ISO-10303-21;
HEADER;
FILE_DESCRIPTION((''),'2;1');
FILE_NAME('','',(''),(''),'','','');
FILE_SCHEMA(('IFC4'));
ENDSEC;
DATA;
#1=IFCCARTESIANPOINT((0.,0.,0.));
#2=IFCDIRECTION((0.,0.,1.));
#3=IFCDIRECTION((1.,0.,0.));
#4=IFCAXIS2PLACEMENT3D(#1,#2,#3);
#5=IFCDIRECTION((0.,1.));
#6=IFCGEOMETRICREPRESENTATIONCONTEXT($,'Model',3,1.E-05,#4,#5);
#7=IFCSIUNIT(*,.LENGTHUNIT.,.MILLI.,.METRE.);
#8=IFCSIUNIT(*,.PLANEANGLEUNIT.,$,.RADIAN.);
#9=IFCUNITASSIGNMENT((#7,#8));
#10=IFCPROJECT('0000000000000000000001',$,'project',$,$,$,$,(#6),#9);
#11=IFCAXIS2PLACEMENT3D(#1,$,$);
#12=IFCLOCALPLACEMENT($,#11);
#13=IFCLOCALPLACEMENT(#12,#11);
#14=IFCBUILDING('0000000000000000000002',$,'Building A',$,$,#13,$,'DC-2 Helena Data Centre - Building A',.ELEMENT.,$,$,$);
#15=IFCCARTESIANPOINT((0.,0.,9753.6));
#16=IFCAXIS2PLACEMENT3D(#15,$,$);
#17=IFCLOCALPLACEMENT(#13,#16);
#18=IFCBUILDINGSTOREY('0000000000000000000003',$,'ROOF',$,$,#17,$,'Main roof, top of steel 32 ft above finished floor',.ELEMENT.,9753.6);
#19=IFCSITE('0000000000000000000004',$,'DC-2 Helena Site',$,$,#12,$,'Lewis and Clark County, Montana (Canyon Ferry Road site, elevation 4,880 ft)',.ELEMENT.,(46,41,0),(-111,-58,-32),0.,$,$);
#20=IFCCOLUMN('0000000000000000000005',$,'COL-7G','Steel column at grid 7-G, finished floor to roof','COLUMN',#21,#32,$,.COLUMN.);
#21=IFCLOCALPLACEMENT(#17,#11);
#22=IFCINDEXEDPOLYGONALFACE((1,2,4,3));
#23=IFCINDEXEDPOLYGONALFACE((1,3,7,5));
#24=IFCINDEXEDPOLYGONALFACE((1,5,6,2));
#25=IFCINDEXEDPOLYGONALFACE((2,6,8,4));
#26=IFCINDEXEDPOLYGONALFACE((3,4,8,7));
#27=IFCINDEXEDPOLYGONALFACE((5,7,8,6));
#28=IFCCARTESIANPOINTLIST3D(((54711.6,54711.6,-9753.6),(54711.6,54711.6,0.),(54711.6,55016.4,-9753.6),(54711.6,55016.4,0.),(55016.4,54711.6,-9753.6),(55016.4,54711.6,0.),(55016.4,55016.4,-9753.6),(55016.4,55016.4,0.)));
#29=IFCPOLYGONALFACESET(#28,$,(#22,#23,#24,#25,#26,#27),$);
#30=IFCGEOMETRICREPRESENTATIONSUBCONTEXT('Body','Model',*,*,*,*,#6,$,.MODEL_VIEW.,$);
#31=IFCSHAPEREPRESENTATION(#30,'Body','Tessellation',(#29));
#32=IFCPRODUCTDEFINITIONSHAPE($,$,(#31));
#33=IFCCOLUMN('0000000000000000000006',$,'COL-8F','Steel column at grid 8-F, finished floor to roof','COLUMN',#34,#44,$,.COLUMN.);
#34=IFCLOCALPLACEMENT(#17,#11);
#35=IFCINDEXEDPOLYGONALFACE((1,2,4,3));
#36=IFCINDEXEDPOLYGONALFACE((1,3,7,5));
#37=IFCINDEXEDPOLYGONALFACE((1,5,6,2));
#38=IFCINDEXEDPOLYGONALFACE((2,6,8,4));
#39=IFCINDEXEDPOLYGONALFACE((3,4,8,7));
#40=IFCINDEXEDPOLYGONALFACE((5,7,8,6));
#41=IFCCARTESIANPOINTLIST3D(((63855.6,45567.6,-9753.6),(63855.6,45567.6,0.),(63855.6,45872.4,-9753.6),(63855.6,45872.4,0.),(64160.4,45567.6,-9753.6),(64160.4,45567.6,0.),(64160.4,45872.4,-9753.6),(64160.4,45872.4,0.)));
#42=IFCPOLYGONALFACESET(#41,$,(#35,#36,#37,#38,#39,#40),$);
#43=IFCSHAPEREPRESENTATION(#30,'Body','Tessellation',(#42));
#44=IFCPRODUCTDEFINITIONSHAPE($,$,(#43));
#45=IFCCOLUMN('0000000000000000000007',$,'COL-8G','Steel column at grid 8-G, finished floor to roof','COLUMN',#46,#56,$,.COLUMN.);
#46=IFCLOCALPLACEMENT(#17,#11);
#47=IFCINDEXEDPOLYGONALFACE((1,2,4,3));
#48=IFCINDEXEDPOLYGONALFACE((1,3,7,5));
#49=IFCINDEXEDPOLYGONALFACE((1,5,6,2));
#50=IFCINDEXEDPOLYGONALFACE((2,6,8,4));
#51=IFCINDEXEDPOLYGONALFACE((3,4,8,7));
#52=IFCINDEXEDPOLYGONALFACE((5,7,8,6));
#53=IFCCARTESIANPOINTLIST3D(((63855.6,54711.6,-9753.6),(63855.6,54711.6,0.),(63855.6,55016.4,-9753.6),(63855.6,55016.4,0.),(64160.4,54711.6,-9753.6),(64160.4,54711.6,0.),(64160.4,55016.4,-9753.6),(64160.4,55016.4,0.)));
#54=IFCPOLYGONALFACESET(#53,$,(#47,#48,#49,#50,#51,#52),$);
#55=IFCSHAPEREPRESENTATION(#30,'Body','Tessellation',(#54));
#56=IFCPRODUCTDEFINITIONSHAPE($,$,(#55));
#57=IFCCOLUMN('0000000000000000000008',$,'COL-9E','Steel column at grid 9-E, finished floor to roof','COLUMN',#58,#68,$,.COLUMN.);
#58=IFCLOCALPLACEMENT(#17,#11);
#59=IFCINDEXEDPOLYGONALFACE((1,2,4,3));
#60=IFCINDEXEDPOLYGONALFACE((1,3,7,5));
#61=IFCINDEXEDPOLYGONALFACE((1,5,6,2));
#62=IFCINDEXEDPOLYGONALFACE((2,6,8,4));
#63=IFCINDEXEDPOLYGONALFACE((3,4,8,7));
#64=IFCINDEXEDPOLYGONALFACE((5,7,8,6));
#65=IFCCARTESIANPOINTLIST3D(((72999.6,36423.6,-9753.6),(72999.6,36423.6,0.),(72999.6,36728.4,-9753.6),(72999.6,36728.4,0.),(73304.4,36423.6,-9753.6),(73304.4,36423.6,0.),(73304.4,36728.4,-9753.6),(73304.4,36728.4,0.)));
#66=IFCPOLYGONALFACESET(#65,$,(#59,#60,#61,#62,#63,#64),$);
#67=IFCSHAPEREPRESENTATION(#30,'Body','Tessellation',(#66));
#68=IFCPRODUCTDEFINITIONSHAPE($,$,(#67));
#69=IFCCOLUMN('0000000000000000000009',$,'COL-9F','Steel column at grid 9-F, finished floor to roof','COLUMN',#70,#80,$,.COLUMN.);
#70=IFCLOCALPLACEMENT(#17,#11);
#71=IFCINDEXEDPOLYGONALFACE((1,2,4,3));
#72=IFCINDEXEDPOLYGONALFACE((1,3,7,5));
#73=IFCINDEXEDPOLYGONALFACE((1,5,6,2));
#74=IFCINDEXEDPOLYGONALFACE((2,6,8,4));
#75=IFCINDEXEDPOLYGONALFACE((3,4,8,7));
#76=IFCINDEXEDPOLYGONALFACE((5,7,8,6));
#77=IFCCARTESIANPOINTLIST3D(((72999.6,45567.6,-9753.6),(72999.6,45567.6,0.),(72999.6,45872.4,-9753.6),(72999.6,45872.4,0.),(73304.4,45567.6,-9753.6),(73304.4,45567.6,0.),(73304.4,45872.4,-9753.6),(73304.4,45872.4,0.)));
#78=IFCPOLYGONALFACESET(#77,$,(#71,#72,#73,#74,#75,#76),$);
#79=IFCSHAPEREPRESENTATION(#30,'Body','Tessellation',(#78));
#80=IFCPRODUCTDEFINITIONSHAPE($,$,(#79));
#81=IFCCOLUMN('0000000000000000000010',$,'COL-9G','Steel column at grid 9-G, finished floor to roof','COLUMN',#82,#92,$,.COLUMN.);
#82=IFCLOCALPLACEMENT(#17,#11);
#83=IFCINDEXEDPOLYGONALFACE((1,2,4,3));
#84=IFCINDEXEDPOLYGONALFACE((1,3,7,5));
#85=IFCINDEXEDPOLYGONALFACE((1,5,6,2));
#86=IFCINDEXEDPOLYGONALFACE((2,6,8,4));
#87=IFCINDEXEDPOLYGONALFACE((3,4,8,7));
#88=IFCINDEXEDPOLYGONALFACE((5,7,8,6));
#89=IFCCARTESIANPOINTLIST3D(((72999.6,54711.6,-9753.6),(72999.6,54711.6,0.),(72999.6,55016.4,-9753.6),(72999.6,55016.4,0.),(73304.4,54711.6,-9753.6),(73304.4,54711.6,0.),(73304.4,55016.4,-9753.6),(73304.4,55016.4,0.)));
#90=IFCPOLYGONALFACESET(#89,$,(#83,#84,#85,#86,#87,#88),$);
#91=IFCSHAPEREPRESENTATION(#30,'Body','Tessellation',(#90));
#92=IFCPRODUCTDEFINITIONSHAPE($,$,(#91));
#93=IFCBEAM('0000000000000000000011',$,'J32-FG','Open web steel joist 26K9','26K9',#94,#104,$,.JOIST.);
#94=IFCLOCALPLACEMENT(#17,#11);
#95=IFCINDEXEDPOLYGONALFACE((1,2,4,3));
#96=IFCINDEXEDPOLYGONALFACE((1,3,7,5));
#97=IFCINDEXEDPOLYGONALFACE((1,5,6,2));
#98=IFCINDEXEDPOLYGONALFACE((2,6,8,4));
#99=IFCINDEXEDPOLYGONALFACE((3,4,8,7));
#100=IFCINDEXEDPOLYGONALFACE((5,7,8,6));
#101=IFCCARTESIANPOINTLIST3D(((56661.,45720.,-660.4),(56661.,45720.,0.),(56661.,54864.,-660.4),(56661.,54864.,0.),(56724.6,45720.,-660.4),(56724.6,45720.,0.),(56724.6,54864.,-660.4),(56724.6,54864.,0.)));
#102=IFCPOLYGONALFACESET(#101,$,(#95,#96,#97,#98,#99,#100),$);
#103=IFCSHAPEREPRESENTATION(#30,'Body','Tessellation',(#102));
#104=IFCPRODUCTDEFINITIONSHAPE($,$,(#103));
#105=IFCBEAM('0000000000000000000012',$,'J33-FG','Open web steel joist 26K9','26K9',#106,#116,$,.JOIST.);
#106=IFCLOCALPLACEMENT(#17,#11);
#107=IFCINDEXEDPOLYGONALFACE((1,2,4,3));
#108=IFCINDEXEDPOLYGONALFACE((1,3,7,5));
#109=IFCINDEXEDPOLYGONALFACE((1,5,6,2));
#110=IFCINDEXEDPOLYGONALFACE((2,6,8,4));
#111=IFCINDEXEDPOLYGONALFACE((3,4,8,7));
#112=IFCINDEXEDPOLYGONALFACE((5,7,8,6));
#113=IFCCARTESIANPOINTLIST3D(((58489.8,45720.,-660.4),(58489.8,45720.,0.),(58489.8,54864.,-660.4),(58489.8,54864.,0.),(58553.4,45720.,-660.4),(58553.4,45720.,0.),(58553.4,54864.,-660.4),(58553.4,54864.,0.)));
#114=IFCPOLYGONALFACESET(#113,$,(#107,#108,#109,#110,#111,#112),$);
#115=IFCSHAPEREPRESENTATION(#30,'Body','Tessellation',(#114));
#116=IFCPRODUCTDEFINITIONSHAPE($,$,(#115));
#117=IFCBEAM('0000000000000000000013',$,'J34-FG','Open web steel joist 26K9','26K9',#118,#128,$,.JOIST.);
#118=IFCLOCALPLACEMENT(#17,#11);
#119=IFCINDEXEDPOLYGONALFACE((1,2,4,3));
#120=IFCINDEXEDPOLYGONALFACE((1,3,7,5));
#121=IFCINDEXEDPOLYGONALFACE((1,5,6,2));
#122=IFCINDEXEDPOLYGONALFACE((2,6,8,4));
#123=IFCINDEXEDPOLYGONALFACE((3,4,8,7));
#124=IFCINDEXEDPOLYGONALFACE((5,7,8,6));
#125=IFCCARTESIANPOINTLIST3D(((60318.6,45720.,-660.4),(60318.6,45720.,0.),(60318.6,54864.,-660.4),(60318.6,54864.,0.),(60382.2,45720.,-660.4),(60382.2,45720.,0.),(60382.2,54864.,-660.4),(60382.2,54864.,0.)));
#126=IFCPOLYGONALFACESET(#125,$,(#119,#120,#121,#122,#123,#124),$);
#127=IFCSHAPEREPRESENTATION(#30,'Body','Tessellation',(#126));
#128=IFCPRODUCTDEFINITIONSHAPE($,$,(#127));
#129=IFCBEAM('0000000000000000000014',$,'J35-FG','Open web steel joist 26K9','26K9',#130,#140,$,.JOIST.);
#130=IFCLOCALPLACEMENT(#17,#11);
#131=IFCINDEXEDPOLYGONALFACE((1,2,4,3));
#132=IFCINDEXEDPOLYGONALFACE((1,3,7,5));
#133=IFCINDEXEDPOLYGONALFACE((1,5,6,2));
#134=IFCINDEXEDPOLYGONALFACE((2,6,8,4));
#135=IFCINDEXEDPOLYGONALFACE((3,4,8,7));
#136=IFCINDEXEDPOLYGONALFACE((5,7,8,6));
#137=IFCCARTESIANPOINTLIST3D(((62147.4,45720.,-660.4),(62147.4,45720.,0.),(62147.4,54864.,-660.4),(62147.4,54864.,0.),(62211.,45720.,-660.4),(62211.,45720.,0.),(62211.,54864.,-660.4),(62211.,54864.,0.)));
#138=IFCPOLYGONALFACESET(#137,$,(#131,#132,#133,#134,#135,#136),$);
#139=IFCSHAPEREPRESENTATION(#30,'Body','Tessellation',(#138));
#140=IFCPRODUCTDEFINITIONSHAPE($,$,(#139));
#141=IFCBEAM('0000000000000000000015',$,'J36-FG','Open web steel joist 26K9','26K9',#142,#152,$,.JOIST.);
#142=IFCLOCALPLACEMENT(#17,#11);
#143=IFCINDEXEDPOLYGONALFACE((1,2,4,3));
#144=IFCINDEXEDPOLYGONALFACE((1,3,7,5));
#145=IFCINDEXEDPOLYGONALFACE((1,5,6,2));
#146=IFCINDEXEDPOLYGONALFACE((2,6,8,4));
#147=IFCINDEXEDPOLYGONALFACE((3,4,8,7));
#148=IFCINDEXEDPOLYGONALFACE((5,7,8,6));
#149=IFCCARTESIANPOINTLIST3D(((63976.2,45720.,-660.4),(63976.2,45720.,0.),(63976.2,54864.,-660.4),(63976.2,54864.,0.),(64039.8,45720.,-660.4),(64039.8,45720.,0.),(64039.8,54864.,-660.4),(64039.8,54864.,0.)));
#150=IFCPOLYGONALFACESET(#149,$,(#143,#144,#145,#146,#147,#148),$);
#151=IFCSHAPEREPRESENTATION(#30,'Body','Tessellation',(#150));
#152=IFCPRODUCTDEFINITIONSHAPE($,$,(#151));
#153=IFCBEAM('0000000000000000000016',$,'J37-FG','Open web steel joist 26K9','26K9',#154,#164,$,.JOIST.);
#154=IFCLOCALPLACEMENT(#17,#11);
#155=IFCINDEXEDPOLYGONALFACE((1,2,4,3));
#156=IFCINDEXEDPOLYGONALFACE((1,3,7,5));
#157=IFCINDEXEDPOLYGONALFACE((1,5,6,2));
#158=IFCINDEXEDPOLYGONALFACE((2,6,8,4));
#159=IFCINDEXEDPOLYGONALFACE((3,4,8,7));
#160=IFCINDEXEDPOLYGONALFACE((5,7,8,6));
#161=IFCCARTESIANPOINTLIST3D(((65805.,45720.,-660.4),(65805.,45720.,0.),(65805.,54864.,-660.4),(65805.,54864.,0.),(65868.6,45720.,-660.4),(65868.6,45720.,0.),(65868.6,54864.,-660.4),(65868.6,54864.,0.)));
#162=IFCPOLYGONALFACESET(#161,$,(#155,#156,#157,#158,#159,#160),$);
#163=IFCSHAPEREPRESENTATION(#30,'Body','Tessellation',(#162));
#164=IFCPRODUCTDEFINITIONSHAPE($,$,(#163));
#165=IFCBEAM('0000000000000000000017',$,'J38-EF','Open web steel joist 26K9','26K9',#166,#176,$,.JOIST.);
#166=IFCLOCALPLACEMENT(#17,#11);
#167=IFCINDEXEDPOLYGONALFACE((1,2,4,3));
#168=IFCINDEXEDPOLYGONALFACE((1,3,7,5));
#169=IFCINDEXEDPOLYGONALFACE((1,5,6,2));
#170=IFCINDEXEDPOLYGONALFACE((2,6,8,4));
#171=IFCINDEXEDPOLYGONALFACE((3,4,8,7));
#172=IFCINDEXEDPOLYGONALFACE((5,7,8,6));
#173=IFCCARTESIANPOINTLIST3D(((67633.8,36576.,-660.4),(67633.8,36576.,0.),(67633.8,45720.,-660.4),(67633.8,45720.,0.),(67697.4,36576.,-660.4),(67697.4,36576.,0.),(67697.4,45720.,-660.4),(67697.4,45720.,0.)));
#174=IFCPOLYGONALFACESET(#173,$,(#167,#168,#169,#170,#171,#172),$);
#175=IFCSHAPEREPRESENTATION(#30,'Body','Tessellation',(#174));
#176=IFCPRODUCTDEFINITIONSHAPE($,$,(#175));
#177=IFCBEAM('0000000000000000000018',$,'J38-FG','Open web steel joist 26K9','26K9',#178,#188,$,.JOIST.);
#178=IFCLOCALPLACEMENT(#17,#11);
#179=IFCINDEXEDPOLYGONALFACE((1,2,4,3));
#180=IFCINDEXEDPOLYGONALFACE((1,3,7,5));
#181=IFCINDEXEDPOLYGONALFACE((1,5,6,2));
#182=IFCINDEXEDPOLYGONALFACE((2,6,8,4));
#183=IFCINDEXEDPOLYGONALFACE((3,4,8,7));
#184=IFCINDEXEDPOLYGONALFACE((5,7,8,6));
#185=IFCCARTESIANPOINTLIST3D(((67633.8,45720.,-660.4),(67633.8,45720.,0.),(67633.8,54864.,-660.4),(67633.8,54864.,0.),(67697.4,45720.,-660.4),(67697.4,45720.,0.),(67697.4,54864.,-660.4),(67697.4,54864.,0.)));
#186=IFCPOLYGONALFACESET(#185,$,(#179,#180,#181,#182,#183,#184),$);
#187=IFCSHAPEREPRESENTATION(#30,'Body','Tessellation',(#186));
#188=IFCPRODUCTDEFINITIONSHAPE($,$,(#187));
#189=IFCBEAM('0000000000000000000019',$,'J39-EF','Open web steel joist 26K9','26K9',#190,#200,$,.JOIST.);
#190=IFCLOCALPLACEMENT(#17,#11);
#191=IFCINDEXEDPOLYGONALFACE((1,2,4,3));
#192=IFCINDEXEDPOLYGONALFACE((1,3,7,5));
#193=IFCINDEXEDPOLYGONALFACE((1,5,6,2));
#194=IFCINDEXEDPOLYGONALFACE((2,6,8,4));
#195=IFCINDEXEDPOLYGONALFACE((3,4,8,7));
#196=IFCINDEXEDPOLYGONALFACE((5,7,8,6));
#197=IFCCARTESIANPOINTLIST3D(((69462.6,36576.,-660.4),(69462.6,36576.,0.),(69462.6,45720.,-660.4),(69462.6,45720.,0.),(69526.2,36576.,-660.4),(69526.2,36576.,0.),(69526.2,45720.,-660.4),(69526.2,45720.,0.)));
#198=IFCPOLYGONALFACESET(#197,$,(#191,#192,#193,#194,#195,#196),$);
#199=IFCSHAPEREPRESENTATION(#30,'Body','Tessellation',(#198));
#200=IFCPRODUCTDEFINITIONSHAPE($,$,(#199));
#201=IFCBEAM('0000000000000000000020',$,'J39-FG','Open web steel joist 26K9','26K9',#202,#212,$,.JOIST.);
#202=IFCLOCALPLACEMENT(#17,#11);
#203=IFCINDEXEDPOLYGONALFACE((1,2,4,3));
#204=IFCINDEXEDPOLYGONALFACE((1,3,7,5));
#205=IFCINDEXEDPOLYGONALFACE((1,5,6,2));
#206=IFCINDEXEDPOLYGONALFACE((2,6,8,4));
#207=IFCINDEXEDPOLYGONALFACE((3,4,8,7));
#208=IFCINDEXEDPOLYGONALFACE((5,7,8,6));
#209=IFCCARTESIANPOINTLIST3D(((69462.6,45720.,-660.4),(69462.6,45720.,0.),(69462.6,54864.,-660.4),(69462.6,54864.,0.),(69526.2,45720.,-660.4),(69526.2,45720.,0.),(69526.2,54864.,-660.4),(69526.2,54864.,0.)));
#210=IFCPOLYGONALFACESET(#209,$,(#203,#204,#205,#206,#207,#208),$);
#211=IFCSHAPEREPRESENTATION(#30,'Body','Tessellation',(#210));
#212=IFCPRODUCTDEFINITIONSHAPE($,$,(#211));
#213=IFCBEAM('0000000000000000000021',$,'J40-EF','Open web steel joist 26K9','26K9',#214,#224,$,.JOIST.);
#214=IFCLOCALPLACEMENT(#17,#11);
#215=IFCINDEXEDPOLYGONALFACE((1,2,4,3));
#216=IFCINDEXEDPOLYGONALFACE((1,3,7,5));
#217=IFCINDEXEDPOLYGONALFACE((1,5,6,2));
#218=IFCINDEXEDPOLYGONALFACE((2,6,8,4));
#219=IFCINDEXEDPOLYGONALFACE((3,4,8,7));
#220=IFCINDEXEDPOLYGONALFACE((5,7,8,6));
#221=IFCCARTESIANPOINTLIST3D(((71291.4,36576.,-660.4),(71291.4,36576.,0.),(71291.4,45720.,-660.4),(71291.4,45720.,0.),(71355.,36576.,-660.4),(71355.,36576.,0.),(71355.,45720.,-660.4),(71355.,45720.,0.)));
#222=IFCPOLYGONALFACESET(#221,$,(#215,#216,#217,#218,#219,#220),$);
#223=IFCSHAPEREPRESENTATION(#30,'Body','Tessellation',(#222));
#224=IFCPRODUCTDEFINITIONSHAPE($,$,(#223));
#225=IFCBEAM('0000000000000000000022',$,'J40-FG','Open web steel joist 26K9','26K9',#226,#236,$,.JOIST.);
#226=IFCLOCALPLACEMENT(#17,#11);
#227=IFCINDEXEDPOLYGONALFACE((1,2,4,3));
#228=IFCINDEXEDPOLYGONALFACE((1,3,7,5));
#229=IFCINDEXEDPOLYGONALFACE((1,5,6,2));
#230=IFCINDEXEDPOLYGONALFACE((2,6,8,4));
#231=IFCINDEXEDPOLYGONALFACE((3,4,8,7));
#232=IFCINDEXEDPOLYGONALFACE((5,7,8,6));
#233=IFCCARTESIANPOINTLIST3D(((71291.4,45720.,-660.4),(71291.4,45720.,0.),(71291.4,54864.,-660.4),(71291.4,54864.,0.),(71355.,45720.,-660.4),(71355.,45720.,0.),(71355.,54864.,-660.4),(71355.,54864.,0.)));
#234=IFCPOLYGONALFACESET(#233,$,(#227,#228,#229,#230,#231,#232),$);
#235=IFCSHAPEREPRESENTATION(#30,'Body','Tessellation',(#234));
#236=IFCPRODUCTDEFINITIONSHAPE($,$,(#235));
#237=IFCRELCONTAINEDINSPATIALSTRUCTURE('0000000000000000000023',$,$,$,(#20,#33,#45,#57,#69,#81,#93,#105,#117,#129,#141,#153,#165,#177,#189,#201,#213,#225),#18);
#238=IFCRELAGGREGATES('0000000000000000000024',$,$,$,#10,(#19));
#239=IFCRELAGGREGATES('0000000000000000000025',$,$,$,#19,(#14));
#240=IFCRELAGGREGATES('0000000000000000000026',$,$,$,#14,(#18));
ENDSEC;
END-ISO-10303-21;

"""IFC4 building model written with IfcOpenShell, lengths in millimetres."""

from ifc_helpers import new_model, si_unit, direction, frame, origin, origin_with_axes, origin_2d, place, context, subcontext, project, spatial, rectangle, extrude, element, save


model = new_model("IFC4")

# Units and contexts
model_context = context("Model", 3, precision=1e-05, world=origin_with_axes(), true_north=direction((0.0, 1.0)))
body_context = subcontext(model_context, "Body", "Model", "MODEL_VIEW")
ifc_project = project(units=[si_unit("LENGTHUNIT", "METRE", prefix="MILLI"), si_unit("PLANEANGLEUNIT", "RADIAN")], contexts=[model_context])

# Site, building, storey
site_placement = place(None, origin())
site = spatial("IfcSite", under=ifc_project, at=site_placement, Name="DC-2 Helena Site", LongName="Lewis and Clark County, Montana (Canyon Ferry Road site, elevation 4,880 ft)", CompositionType="ELEMENT", RefLatitude=(46, 41, 0), RefLongitude=(-111, -58, -32), RefElevation=0.0)
building_placement = place(site_placement, origin())
building = spatial("IfcBuilding", under=site, at=building_placement, Name="Building A", LongName="DC-2 Helena Data Centre - Building A", CompositionType="ELEMENT")
storey_placement = place(building_placement, frame((0.0, 0.0, 9753.6)))
storey = spatial("IfcBuildingStorey", under=building, at=storey_placement, Name="ROOF", LongName="Main roof, top of steel 32 ft above finished floor", CompositionType="ELEMENT", Elevation=9753.6)

# Columns
placement_1 = place(storey_placement, frame((54864.0, 54864.0, -9753.6)))
element("IfcColumn", 1, at=placement_1, inside=storey, Name="COL-7G", Description="Steel column at grid 7-G, finished floor to roof", ObjectType="COLUMN", PredefinedType="COLUMN", context=body_context, shape_type="SweptSolid", body=[
    extrude(rectangle(XDim=304.8, YDim=304.8, at=origin_2d()), origin(), (0.0, 0.0, 1.0), 9753.6),
])
for number, where, name, description in (
    (2, (64008.0, 45720.0, -9753.6), "COL-8F", "Steel column at grid 8-F, finished floor to roof"),
    (3, (64008.0, 54864.0, -9753.6), "COL-8G", "Steel column at grid 8-G, finished floor to roof"),
):
    element("IfcColumn", number, at=place(storey_placement, frame(where)), inside=storey, Name=name, Description=description, ObjectType="COLUMN", PredefinedType="COLUMN", context=body_context, shape_type="SweptSolid", body=[
        extrude(rectangle(XDim=304.8, YDim=304.8, at=origin_2d()), origin(), (0.0, 0.0, 1.0), 9753.6),
    ])
placement_2 = place(storey_placement, frame((73152.0, 36576.0, -9753.6)))
element("IfcColumn", 4, at=placement_2, inside=storey, Name="COL-9E", Description="Steel column at grid 9-E, finished floor to roof", ObjectType="COLUMN", PredefinedType="COLUMN", context=body_context, shape_type="SweptSolid", body=[
    extrude(rectangle(XDim=304.8, YDim=304.8, at=origin_2d()), origin(), (0.0, 0.0, 1.0), 9753.6),
])
for number, where, name, description in (
    (5, (73152.0, 45720.0, -9753.6), "COL-9F", "Steel column at grid 9-F, finished floor to roof"),
    (6, (73152.0, 54864.0, -9753.6), "COL-9G", "Steel column at grid 9-G, finished floor to roof"),
):
    element("IfcColumn", number, at=place(storey_placement, frame(where)), inside=storey, Name=name, Description=description, ObjectType="COLUMN", PredefinedType="COLUMN", context=body_context, shape_type="SweptSolid", body=[
        extrude(rectangle(XDim=304.8, YDim=304.8, at=origin_2d()), origin(), (0.0, 0.0, 1.0), 9753.6),
    ])

# Beams
for number, where, name in (
    (7, (56692.8, 45720.0, 0.0), "J32-FG"),
    (8, (58521.6, 45720.0, 0.0), "J33-FG"),
    (9, (60350.4, 45720.0, 0.0), "J34-FG"),
    (10, (62179.2, 45720.0, 0.0), "J35-FG"),
):
    element("IfcBeam", number, at=place(storey_placement, frame(where)), inside=storey, Name=name, Description="Open web steel joist 26K9", ObjectType="26K9", PredefinedType="JOIST", context=body_context, shape_type="SweptSolid", body=[
        extrude(rectangle(XDim=63.5, YDim=660.4, at=origin_2d()), frame((0.0, 0.0, -330.2), z_axis=(0.0, 1.0, 0.0), x_axis=(1.0, 0.0, 0.0)), (0.0, 0.0, 1.0), 9144.0),
    ])
placement_3 = place(storey_placement, frame((64008.0, 45720.0, 0.0)))
element("IfcBeam", 11, at=placement_3, inside=storey, Name="J36-FG", Description="Open web steel joist 26K9", ObjectType="26K9", PredefinedType="JOIST", context=body_context, shape_type="SweptSolid", body=[
    extrude(rectangle(XDim=63.5, YDim=660.4, at=origin_2d()), frame((0.0, 0.0, -330.2), z_axis=(0.0, 1.0, 0.0), x_axis=(1.0, 0.0, 0.0)), (0.0, 0.0, 1.0), 9144.0),
])
for number, where, name in (
    (12, (65836.8, 45720.0, 0.0), "J37-FG"),
    (13, (67665.6, 36576.0, 0.0), "J38-EF"),
    (14, (67665.6, 45720.0, 0.0), "J38-FG"),
    (15, (69494.4, 36576.0, 0.0), "J39-EF"),
    (16, (69494.4, 45720.0, 0.0), "J39-FG"),
    (17, (71323.2, 36576.0, 0.0), "J40-EF"),
    (18, (71323.2, 45720.0, 0.0), "J40-FG"),
):
    element("IfcBeam", number, at=place(storey_placement, frame(where)), inside=storey, Name=name, Description="Open web steel joist 26K9", ObjectType="26K9", PredefinedType="JOIST", context=body_context, shape_type="SweptSolid", body=[
        extrude(rectangle(XDim=63.5, YDim=660.4, at=origin_2d()), frame((0.0, 0.0, -330.2), z_axis=(0.0, 1.0, 0.0), x_axis=(1.0, 0.0, 0.0)), (0.0, 0.0, 1.0), 9144.0),
    ])

save(model, "model.ifc")
